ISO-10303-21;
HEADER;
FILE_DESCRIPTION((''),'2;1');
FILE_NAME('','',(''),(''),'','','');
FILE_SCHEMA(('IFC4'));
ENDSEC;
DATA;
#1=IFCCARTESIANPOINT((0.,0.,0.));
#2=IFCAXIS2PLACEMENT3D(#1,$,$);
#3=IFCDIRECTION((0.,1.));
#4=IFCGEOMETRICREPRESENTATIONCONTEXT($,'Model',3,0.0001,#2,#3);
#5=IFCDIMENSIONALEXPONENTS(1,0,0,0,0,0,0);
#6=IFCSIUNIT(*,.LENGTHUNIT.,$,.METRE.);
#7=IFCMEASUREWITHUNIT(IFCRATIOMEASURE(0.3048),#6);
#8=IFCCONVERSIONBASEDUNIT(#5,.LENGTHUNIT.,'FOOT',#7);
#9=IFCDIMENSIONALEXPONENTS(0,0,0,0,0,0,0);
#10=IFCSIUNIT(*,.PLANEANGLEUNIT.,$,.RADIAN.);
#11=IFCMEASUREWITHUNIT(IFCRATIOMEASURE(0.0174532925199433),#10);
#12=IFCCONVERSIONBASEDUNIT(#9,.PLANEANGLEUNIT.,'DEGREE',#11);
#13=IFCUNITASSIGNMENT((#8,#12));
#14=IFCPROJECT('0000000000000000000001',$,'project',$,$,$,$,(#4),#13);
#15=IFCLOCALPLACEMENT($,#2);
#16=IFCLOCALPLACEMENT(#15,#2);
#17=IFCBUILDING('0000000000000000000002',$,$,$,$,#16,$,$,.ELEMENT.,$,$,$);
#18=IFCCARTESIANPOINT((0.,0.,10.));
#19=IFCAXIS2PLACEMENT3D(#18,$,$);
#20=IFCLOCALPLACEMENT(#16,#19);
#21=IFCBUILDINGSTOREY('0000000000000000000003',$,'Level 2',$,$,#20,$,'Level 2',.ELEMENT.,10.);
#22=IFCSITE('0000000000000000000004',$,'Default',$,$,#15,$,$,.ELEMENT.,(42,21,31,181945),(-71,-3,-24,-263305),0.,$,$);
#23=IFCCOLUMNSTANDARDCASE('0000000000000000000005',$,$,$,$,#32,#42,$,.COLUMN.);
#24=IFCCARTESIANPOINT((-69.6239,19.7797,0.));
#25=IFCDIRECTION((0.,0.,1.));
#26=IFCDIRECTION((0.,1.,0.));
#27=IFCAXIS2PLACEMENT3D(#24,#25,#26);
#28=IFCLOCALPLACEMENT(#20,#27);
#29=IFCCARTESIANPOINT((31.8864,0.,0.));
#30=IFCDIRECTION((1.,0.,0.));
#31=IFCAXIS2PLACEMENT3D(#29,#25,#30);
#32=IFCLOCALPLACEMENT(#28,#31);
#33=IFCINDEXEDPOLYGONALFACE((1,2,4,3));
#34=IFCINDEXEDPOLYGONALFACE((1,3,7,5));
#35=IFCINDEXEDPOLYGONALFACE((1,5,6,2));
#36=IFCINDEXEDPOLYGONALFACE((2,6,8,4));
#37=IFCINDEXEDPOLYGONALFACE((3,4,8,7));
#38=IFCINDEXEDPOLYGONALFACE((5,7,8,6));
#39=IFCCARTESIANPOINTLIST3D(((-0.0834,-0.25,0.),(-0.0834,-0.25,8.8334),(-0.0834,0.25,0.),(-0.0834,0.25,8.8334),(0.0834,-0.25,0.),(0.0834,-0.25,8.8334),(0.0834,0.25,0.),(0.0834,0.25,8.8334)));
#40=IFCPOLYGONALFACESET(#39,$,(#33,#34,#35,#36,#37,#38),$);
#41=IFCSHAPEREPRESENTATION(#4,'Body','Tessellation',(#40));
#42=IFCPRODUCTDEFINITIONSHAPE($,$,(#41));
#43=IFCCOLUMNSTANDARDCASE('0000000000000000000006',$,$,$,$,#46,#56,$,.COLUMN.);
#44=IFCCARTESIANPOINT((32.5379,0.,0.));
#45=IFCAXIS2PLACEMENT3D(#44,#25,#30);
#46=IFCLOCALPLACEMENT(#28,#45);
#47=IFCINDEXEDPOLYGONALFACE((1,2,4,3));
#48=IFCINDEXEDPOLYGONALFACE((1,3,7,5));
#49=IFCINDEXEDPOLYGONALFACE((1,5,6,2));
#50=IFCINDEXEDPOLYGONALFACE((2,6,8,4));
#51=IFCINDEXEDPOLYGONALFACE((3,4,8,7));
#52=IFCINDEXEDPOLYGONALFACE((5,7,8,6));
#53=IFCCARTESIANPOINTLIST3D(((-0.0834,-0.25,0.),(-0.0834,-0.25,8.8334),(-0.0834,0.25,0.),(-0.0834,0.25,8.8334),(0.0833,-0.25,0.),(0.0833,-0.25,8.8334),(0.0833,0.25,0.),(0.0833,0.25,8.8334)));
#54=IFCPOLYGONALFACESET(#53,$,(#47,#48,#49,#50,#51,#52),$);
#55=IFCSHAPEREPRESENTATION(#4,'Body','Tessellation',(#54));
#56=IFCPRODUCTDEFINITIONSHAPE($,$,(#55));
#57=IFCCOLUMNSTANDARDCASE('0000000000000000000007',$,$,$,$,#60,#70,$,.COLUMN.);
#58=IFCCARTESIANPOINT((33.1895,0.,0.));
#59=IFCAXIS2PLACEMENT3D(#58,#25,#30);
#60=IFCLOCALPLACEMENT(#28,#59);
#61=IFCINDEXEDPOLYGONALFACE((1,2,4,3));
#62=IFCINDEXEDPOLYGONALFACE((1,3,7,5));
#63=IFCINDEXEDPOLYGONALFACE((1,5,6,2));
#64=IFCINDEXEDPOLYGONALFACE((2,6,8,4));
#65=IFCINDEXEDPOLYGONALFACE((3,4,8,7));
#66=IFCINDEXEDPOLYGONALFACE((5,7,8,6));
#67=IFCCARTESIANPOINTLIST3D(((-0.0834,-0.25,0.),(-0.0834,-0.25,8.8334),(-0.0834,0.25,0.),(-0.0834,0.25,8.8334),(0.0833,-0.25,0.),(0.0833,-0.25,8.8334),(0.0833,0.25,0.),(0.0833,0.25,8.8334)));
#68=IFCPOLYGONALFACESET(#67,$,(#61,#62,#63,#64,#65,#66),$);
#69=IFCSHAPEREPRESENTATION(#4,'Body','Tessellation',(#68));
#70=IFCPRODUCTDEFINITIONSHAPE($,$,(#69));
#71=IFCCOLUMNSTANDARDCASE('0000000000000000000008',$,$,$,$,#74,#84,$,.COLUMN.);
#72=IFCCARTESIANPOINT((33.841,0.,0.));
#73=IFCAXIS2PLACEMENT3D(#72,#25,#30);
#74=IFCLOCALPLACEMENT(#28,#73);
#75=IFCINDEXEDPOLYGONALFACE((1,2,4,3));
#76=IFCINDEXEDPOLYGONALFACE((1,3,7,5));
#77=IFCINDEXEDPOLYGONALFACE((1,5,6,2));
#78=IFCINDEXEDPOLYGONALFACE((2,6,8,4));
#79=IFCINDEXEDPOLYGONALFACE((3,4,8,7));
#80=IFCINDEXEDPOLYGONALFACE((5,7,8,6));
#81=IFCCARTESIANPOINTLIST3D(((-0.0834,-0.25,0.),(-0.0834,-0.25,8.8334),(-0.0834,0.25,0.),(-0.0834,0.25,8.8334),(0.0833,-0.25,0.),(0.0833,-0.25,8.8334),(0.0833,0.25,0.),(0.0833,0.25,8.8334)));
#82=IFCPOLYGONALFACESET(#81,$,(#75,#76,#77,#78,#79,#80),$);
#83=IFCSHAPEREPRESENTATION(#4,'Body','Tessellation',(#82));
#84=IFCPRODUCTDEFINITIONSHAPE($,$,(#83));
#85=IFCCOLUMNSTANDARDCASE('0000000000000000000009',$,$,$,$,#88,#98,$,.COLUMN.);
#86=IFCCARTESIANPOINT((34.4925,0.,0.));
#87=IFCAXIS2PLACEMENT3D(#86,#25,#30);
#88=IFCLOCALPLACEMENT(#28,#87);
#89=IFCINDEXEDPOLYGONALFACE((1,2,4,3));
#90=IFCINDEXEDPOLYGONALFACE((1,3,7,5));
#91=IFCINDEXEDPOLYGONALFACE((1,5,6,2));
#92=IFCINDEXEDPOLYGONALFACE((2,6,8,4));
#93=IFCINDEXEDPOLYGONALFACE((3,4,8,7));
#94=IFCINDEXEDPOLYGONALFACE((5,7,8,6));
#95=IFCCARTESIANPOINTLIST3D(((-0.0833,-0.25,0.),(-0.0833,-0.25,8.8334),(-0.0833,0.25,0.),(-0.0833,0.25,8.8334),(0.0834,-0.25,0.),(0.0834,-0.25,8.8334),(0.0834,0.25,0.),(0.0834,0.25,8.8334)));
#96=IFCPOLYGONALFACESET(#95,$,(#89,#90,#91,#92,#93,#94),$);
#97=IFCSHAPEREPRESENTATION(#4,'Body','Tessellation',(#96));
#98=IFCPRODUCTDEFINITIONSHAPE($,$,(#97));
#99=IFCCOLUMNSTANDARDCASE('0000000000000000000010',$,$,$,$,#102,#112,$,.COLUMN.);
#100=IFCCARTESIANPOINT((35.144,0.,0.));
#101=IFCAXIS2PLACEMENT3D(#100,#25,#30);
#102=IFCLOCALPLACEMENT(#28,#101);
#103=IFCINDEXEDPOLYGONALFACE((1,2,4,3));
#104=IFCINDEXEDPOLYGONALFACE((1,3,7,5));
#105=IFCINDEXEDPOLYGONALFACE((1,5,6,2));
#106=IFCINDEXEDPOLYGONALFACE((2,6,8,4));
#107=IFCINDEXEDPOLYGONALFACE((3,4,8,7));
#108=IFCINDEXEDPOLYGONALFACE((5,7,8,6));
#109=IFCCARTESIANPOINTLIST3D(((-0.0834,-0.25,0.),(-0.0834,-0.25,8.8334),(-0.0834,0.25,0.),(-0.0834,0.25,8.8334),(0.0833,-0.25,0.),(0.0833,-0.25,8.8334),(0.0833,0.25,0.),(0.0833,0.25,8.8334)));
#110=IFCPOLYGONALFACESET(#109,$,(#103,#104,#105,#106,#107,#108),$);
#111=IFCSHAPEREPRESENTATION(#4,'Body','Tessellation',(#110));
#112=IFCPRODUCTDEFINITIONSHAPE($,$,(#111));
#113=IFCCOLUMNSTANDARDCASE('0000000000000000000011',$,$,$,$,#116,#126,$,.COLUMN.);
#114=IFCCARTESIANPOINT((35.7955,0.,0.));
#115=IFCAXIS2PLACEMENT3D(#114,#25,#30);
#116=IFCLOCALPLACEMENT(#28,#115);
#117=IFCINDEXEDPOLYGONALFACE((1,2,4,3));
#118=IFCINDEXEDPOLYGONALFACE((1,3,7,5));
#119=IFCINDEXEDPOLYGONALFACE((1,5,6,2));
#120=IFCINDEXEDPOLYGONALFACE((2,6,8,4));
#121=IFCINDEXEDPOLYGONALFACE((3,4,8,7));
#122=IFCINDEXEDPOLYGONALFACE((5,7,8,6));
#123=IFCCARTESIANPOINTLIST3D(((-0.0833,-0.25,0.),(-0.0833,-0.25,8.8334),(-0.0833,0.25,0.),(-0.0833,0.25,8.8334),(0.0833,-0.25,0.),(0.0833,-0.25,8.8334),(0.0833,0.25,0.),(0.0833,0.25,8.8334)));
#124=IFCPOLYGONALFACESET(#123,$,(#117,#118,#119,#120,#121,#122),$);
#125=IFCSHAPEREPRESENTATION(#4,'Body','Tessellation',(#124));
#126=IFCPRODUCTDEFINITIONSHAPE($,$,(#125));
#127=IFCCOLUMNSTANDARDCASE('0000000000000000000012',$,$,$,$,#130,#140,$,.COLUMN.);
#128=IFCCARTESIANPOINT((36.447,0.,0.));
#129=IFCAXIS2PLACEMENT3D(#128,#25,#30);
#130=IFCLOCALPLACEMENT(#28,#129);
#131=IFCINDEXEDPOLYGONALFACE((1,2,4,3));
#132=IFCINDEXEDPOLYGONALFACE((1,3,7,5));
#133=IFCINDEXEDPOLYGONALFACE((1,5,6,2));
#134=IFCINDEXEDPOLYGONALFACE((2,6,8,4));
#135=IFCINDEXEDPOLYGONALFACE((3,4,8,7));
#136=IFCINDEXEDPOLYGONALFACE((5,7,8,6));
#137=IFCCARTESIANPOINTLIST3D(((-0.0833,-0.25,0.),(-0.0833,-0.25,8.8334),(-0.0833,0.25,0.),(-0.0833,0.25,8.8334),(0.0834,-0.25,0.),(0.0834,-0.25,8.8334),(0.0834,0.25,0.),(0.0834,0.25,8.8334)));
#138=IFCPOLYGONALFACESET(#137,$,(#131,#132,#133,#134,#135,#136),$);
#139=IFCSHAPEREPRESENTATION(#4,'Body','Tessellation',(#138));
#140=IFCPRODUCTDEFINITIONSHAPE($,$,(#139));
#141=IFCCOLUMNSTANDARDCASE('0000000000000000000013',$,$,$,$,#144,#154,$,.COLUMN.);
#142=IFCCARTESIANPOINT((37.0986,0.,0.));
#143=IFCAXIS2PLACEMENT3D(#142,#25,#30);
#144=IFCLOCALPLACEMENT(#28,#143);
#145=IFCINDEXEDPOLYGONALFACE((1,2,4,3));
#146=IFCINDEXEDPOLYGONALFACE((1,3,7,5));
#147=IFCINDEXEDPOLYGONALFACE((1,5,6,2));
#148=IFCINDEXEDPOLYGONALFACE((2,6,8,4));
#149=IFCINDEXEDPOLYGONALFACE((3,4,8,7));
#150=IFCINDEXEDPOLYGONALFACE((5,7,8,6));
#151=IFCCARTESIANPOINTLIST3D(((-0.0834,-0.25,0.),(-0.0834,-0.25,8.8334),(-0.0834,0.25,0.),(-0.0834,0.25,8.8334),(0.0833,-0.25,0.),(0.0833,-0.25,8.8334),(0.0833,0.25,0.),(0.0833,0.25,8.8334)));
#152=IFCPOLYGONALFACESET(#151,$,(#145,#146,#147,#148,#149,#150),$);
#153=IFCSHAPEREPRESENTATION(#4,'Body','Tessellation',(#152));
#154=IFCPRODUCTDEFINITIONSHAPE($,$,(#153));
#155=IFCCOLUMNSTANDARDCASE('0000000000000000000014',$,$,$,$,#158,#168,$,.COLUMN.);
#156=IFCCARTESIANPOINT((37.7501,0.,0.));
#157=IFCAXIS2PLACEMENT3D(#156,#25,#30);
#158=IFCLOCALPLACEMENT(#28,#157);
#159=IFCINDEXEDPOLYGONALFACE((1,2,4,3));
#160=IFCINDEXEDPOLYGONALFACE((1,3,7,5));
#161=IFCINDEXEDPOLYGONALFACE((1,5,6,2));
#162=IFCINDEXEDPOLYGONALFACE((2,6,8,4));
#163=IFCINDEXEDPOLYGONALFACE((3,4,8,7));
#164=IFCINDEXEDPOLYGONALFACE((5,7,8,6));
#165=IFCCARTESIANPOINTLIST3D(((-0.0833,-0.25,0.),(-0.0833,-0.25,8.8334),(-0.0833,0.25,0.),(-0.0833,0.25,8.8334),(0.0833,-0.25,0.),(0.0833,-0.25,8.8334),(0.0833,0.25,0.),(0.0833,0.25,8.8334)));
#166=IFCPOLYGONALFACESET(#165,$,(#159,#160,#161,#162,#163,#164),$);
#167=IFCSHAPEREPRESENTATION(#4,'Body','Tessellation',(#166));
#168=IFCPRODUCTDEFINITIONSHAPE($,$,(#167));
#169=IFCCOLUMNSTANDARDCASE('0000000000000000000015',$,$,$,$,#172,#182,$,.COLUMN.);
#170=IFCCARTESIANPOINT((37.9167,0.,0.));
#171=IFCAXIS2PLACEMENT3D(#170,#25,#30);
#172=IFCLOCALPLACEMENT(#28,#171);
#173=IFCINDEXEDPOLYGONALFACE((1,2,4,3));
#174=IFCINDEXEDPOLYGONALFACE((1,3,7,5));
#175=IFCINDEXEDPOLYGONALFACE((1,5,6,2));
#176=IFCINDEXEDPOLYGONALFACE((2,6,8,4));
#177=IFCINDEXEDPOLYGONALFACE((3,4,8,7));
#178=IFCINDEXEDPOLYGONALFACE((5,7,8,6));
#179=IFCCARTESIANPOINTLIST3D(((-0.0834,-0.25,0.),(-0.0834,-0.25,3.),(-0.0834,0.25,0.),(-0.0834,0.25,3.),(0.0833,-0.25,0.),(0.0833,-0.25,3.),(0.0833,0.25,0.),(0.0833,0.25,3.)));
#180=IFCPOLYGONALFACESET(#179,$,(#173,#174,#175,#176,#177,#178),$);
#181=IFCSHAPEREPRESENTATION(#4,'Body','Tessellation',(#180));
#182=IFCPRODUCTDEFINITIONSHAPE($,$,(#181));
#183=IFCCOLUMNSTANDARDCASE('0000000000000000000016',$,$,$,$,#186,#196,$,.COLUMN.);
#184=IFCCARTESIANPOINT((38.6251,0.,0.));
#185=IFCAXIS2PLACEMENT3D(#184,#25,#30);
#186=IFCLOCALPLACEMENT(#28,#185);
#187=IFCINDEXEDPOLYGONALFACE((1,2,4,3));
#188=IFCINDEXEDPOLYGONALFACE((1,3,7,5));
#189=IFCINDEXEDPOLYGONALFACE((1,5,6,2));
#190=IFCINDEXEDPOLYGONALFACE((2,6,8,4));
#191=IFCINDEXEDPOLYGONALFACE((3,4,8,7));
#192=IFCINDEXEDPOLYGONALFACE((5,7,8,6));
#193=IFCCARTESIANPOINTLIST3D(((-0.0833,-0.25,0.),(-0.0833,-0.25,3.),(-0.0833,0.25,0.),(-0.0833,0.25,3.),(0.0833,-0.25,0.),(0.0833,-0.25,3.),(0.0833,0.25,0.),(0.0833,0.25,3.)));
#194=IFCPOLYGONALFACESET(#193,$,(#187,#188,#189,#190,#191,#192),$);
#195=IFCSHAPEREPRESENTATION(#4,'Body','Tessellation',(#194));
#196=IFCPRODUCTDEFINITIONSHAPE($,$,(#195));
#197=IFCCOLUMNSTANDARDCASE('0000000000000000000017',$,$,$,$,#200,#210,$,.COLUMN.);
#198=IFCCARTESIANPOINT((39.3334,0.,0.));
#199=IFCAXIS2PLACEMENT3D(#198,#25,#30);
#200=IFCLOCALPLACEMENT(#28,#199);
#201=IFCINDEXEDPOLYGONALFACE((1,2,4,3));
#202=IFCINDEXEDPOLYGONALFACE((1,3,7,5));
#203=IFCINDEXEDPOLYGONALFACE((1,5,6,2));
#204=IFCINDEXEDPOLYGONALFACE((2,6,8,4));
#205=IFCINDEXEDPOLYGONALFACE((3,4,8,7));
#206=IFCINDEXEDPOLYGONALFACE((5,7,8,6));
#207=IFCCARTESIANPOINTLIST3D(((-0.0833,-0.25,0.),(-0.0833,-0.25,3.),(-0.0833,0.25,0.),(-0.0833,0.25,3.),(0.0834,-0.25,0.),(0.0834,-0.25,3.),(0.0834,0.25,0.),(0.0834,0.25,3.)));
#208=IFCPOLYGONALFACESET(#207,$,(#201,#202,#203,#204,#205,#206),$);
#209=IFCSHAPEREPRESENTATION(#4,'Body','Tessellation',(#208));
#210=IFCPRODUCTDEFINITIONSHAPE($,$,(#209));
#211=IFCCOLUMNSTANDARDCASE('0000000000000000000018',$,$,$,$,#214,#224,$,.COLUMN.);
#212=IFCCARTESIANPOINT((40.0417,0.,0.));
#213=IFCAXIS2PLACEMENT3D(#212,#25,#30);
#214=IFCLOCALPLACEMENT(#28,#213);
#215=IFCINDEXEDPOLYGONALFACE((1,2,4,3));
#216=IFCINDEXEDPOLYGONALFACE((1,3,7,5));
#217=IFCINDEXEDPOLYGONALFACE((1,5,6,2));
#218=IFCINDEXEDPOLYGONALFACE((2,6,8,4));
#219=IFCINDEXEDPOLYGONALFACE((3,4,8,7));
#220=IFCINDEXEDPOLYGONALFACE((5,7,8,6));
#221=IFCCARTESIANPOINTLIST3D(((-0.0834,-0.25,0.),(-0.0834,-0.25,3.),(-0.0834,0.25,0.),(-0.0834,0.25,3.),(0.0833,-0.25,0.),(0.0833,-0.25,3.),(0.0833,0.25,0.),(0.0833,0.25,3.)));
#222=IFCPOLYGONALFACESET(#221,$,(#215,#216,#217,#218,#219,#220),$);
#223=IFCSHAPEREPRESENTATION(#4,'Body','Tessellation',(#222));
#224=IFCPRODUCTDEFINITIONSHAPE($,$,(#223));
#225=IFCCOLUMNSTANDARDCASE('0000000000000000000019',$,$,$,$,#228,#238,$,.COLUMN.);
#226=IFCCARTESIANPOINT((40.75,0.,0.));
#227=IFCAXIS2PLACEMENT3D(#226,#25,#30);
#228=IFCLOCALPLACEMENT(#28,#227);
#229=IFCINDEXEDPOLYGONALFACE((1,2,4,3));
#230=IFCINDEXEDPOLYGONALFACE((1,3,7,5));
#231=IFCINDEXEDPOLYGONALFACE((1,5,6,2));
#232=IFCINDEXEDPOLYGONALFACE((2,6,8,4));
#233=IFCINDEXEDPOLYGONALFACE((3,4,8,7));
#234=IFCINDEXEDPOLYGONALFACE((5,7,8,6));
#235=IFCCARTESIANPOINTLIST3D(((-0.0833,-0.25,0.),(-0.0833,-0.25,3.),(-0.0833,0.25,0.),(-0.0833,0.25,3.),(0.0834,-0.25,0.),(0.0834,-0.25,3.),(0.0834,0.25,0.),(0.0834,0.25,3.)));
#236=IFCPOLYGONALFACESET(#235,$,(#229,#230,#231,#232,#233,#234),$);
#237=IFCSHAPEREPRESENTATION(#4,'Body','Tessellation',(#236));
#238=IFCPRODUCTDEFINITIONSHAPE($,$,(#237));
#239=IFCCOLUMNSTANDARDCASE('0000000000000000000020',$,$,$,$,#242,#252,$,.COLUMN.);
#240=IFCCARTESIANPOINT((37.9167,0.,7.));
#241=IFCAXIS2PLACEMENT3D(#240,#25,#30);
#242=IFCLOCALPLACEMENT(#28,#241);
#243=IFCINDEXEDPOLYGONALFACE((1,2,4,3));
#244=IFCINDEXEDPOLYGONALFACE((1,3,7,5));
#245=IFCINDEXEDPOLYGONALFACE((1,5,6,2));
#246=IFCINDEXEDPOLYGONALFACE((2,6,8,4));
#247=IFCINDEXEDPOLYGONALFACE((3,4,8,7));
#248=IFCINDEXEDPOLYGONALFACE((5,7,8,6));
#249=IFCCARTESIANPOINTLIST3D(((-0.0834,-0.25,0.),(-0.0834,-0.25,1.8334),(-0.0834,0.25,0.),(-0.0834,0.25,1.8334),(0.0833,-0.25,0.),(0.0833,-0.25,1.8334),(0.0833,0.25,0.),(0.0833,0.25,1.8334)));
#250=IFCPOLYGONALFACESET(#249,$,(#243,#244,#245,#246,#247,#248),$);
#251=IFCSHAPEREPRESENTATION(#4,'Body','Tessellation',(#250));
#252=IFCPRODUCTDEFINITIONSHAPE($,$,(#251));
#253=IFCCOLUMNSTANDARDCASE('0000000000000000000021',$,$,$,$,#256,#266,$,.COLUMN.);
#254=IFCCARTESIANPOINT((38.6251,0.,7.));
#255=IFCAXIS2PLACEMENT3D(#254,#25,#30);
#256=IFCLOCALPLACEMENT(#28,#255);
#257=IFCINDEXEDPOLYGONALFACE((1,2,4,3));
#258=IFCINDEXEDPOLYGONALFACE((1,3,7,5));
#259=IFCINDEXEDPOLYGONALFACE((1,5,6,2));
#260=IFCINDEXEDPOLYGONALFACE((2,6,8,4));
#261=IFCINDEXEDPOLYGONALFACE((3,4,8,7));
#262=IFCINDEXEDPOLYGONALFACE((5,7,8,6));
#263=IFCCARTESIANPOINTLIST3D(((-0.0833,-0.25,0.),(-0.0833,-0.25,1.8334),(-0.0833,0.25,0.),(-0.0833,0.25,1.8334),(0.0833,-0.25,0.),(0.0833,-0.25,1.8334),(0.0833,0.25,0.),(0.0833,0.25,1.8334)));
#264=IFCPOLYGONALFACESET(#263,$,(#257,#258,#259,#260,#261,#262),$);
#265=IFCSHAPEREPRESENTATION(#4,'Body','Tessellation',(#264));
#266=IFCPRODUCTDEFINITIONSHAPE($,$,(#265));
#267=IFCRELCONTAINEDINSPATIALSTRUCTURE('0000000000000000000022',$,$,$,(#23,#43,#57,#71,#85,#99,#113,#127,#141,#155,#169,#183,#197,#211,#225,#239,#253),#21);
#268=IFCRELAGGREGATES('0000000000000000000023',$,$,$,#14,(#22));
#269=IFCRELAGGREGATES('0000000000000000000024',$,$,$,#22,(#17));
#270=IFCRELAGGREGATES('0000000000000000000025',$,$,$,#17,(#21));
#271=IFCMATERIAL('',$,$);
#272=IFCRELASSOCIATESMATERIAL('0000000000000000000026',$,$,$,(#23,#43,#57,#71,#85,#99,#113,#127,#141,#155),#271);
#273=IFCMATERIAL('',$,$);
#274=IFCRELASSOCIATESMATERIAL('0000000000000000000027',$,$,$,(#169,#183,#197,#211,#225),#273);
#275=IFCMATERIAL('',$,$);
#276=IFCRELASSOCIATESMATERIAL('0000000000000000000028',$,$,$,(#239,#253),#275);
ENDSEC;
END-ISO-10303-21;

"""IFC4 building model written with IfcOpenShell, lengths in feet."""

from ifc_helpers import new_model, entity, si_unit, converted_unit, direction, frame, origin, place, context, project, spatial, rectangle, extrude, material, element, save


model = new_model("IFC4")

# Units and contexts
model_context = context("Model", 3, precision=0.0001, world=origin(), true_north=direction((0.0, 1.0)))
ifc_project = project(units=[converted_unit("LENGTHUNIT", "FOOT", entity("IfcRatioMeasure", 0.3048), si_unit("LENGTHUNIT", "METRE"), dimensions=[1, 0, 0, 0, 0, 0, 0]), converted_unit("PLANEANGLEUNIT", "DEGREE", entity("IfcRatioMeasure", 0.0174532925199433), si_unit("PLANEANGLEUNIT", "RADIAN"), dimensions=[0, 0, 0, 0, 0, 0, 0])], contexts=[model_context])

# Site, building, storey
site_placement = place(None, origin())
site = spatial("IfcSite", under=ifc_project, at=site_placement, Name="Default", CompositionType="ELEMENT", RefLatitude=(42, 21, 31, 181945), RefLongitude=(-71, -3, -24, -263305), RefElevation=0.0)
building_placement = place(site_placement, origin())
building = spatial("IfcBuilding", under=site, at=building_placement, CompositionType="ELEMENT")
storey_placement = place(building_placement, frame((0.0, 0.0, 10.0)))
storey = spatial("IfcBuildingStorey", under=building, at=storey_placement, Name="Level 2", LongName="Level 2", CompositionType="ELEMENT", Elevation=10.0)

# Columns
ifc_material_1 = material(Name="")
placement = place(storey_placement, frame((-69.6239, 19.7797, 0.0), z_axis=(0.0, 0.0, 1.0), x_axis=(0.0, 1.0, 0.0)))
for number, where, z_axis, x_axis in (
    (1, (31.8864, 0.0, 0.0), (0.0, 0.0, 1.0), (1.0, 0.0, 0.0)),
    (2, (32.5379, 0.0, 0.0), (0.0, 0.0, 1.0), (1.0, 0.0, 0.0)),
    (3, (33.1895, 0.0, 0.0), (0.0, 0.0, 1.0), (1.0, 0.0, 0.0)),
    (4, (33.841, 0.0, 0.0), (0.0, 0.0, 1.0), (1.0, 0.0, 0.0)),
    (5, (34.4925, 0.0, 0.0), (0.0, 0.0, 1.0), (1.0, 0.0, 0.0)),
    (6, (35.144, 0.0, 0.0), (0.0, 0.0, 1.0), (1.0, 0.0, 0.0)),
    (7, (35.7955, 0.0, 0.0), (0.0, 0.0, 1.0), (1.0, 0.0, 0.0)),
    (8, (36.447, 0.0, 0.0), (0.0, 0.0, 1.0), (1.0, 0.0, 0.0)),
    (9, (37.0986, 0.0, 0.0), (0.0, 0.0, 1.0), (1.0, 0.0, 0.0)),
    (10, (37.7501, 0.0, 0.0), (0.0, 0.0, 1.0), (1.0, 0.0, 0.0)),
):
    element("IfcColumnStandardCase", number, at=place(placement, frame(where, z_axis=z_axis, x_axis=x_axis)), inside=storey, material=ifc_material_1, PredefinedType="COLUMN", context=model_context, shape_type="SweptSolid", body=[
        extrude(rectangle(XDim=0.1667, YDim=0.5), origin(), (0.0, 0.0, 1.0), 8.8334),
    ])
ifc_material_2 = material(Name="")
for number, where, z_axis, x_axis in (
    (11, (37.9167, 0.0, 0.0), (0.0, 0.0, 1.0), (1.0, 0.0, 0.0)),
    (12, (38.6251, 0.0, 0.0), (0.0, 0.0, 1.0), (1.0, 0.0, 0.0)),
    (13, (39.3334, 0.0, 0.0), (0.0, 0.0, 1.0), (1.0, 0.0, 0.0)),
    (14, (40.0417, 0.0, 0.0), (0.0, 0.0, 1.0), (1.0, 0.0, 0.0)),
    (15, (40.75, 0.0, 0.0), (0.0, 0.0, 1.0), (1.0, 0.0, 0.0)),
):
    element("IfcColumnStandardCase", number, at=place(placement, frame(where, z_axis=z_axis, x_axis=x_axis)), inside=storey, material=ifc_material_2, PredefinedType="COLUMN", context=model_context, shape_type="SweptSolid", body=[
        extrude(rectangle(XDim=0.1667, YDim=0.5), origin(), (0.0, 0.0, 1.0), 3.0),
    ])
ifc_material_3 = material(Name="")
for number, where, z_axis, x_axis in (
    (16, (37.9167, 0.0, 7.0), (0.0, 0.0, 1.0), (1.0, 0.0, 0.0)),
    (17, (38.6251, 0.0, 7.0), (0.0, 0.0, 1.0), (1.0, 0.0, 0.0)),
):
    element("IfcColumnStandardCase", number, at=place(placement, frame(where, z_axis=z_axis, x_axis=x_axis)), inside=storey, material=ifc_material_3, PredefinedType="COLUMN", context=model_context, shape_type="SweptSolid", body=[
        extrude(rectangle(XDim=0.1667, YDim=0.5), origin(), (0.0, 0.0, 1.0), 1.8334),
    ])

save(model, "model.ifc")
